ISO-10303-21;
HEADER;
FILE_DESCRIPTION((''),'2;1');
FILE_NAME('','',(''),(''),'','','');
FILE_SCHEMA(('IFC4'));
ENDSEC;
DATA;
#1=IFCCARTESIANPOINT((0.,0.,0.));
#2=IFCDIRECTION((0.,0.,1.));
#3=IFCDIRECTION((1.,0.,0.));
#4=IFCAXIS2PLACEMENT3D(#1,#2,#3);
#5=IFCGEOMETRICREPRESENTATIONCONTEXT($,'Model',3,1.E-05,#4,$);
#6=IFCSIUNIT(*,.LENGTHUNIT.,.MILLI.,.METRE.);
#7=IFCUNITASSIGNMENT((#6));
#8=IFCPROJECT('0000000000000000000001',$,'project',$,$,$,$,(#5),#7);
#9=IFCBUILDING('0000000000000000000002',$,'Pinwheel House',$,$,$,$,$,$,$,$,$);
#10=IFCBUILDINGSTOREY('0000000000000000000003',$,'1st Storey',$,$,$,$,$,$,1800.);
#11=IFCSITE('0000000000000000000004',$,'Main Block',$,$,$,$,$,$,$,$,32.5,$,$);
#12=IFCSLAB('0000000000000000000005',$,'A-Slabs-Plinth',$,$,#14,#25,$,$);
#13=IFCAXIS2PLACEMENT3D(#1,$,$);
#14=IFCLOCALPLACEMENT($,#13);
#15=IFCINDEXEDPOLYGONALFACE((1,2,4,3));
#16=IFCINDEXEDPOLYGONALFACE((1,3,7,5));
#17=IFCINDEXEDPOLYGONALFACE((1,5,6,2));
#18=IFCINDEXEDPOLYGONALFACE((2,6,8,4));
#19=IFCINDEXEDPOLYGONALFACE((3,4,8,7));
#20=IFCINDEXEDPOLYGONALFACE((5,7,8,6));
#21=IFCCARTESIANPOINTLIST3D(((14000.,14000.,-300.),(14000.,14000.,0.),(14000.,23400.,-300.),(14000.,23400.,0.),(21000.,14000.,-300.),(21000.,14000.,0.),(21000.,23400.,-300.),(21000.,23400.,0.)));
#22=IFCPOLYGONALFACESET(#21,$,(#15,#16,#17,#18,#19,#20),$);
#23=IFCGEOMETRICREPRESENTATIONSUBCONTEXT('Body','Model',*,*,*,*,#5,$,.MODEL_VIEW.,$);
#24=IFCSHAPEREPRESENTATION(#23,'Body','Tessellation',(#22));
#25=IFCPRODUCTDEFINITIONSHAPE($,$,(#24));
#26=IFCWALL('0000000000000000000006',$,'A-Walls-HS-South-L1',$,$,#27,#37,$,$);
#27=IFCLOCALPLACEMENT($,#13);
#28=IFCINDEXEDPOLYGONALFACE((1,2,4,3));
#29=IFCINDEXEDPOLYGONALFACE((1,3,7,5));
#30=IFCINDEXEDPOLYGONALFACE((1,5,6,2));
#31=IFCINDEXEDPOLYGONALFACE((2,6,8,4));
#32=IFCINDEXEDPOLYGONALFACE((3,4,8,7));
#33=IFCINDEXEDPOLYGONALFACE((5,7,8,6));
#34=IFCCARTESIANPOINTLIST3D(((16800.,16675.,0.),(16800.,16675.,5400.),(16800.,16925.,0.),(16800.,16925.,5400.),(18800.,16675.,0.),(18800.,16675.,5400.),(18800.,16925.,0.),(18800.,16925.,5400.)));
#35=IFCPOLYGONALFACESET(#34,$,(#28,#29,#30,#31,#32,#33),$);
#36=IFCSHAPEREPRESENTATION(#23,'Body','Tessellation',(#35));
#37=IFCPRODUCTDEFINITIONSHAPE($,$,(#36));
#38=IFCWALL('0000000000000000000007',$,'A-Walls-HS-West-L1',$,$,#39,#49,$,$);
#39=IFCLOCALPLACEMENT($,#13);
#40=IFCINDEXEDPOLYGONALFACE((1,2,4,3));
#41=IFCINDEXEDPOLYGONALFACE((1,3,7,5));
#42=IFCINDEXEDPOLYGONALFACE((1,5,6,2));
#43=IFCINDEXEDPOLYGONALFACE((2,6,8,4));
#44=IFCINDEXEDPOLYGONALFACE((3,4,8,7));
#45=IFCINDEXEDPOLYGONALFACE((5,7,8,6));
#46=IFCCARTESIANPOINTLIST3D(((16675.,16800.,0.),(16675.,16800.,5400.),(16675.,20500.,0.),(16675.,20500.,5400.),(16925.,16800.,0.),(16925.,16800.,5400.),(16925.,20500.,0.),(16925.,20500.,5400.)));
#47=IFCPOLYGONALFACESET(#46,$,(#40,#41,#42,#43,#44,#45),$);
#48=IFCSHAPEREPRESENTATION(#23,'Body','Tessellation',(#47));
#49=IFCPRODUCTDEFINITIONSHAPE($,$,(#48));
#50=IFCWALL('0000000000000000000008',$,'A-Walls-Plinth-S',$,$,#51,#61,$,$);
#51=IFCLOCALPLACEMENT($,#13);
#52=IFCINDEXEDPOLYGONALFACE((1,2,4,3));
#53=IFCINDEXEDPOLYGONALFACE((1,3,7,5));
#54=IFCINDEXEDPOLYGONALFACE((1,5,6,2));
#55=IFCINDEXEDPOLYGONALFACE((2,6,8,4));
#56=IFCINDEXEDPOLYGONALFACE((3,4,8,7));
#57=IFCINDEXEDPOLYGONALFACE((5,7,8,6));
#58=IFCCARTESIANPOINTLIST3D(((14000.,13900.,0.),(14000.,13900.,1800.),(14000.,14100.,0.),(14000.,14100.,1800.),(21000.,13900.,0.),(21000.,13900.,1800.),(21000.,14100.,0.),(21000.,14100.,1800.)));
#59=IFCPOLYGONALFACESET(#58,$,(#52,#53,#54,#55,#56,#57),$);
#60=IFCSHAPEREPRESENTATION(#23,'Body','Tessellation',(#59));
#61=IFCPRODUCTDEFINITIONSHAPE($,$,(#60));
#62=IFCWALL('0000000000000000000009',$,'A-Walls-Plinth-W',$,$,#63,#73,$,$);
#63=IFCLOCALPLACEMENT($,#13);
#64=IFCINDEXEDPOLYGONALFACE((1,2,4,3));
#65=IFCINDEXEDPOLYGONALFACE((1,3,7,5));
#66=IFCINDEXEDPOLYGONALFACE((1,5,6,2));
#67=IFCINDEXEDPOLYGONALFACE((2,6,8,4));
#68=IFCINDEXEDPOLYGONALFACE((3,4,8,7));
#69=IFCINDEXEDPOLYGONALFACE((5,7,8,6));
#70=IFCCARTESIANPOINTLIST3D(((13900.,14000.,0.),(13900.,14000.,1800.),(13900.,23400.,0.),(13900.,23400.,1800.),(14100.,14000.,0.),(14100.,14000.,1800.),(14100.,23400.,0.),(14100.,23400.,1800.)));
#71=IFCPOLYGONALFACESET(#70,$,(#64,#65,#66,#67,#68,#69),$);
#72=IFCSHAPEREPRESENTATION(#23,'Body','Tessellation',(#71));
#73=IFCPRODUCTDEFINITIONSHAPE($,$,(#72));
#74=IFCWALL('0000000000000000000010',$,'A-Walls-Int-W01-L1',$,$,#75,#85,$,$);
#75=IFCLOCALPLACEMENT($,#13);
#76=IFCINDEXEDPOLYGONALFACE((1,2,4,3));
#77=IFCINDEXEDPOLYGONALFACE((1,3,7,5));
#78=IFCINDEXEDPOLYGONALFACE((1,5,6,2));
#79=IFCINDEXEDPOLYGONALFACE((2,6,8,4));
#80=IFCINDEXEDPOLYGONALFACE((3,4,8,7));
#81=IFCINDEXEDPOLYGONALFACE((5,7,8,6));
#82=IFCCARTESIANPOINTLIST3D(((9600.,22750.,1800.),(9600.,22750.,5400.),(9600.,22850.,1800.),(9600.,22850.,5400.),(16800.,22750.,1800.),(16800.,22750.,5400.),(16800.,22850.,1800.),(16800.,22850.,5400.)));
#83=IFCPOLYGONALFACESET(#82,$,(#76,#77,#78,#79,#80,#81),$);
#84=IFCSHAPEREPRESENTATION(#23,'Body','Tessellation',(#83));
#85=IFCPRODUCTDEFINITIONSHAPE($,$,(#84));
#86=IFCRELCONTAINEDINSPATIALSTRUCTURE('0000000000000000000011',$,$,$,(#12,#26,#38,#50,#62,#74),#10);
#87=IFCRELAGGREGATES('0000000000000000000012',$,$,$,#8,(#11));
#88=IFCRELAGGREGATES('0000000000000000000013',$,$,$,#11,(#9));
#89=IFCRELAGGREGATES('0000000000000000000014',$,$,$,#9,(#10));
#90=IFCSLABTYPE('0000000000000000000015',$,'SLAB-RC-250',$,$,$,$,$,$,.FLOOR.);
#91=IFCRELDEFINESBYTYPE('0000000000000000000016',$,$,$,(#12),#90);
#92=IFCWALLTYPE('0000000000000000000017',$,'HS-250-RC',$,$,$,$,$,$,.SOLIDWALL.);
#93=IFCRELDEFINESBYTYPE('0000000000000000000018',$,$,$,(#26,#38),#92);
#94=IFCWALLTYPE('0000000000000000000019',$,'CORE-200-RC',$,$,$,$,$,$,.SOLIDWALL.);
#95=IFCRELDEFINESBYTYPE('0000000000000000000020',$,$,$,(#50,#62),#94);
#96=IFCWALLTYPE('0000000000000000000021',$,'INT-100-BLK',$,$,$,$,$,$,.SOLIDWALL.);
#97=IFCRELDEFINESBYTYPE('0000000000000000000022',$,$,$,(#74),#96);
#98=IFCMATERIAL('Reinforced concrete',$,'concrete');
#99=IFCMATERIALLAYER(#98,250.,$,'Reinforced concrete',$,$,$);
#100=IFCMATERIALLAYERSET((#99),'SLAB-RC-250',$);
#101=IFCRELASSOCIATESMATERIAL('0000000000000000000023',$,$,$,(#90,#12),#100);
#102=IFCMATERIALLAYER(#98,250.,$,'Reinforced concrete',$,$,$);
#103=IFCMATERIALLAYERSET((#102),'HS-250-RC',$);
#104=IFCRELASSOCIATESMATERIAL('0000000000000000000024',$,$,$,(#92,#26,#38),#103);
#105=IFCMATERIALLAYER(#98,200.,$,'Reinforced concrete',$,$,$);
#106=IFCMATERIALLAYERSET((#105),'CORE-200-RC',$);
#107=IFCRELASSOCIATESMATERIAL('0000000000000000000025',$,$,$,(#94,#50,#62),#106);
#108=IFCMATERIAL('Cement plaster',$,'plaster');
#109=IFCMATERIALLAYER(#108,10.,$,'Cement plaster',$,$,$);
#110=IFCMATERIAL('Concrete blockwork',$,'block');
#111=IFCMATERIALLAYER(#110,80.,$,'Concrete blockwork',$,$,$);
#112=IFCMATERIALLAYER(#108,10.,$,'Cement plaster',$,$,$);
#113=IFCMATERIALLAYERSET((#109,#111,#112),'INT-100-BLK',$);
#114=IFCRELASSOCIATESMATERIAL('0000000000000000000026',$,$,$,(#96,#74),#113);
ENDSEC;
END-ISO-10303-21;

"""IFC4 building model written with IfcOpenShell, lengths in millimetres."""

from ifc_helpers import new_model, si_unit, frame, origin_with_axes, place, context, subcontext, project, spatial, indexed_curve, outline, extrude, material, layer, layer_set, layer_usage, type_object, element, save


model = new_model("IFC4")

# Units and contexts
model_context = context("Model", 3, precision=1e-05, world=origin_with_axes())
body_context = subcontext(model_context, "Body", "Model", "MODEL_VIEW")
ifc_project = project(units=[si_unit("LENGTHUNIT", "METRE", prefix="MILLI")], contexts=[model_context])

# Site, building, storey
site = spatial("IfcSite", under=ifc_project, Name="Main Block", RefElevation=32.5)
building = spatial("IfcBuilding", under=site, Name="Pinwheel House")
storey = spatial("IfcBuildingStorey", under=building, Name="1st Storey", Elevation=1800.0)

# Slab
ifc_material_1 = material(Name="Reinforced concrete", Category="concrete")
ifc_layer_1 = layer(ifc_material_1, 250.0, Name="Reinforced concrete")
ifc_layer_set_1 = layer_set([ifc_layer_1], Name="SLAB-RC-250")
slab_type = type_object("IfcSlabType", Name="SLAB-RC-250", PredefinedType="FLOOR", material=ifc_layer_set_1)
ifc_layer_usage_1 = layer_usage(ifc_layer_set_1, "AXIS3", "POSITIVE", 0.0)
slab_1_placement = place(None, frame((0.0, 0.0, -300.0), z_axis=(0.0, 0.0, 1.0), x_axis=(1.0, 0.0, 0.0)))
element("IfcSlab", 1, at=slab_1_placement, inside=storey, type_object=slab_type, material=ifc_layer_usage_1, Name="A-Slabs-Plinth", context=body_context, shape_type="SweptSolid", body=[
    extrude(outline(indexed_curve([(14000.0, 14000.0), (21000.0, 14000.0), (21000.0, 23400.0), (14000.0, 23400.0)])), None, (0.0, 0.0, 1.0), 300.0),
])

# Walls
ifc_layer_2 = layer(ifc_material_1, 250.0, Name="Reinforced concrete")
ifc_layer_set_2 = layer_set([ifc_layer_2], Name="HS-250-RC")
ifc_layer_usage_2 = layer_usage(ifc_layer_set_2, "AXIS2", "POSITIVE", 0.0)
wall_type_1 = type_object("IfcWallType", Name="HS-250-RC", PredefinedType="SOLIDWALL", material=ifc_layer_set_2)
wall_1_placement = place(None, frame((16800.0, 16675.0, 0.0), z_axis=(0.0, 0.0, 1.0), x_axis=(1.0, 0.0, 0.0)))
element("IfcWall", 2, at=wall_1_placement, inside=storey, type_object=wall_type_1, material=ifc_layer_usage_2, Name="A-Walls-HS-South-L1", context=body_context, shape_type="SweptSolid", body=[
    extrude(outline(indexed_curve([(0.0, 0.0), (0.0, 250.0), (2000.0, 250.0), (2000.0, 0.0), (0.0, 0.0)], self_intersect=False)), origin_with_axes(), (0.0, 0.0, 1.0), 5400.0),
])
ifc_layer_usage_3 = layer_usage(ifc_layer_set_2, "AXIS2", "POSITIVE", 0.0)
wall_2_placement = place(None, frame((16675.0, 20500.0, 0.0), z_axis=(0.0, 0.0, 1.0), x_axis=(0.0, -1.0, 0.0)))
element("IfcWall", 3, at=wall_2_placement, inside=storey, type_object=wall_type_1, material=ifc_layer_usage_3, Name="A-Walls-HS-West-L1", context=body_context, shape_type="SweptSolid", body=[
    extrude(outline(indexed_curve([(0.0, 0.0), (0.0, 250.0), (3700.0, 250.0), (3700.0, 0.0), (0.0, 0.0)], self_intersect=False)), origin_with_axes(), (0.0, 0.0, 1.0), 5400.0),
])
ifc_layer_3 = layer(ifc_material_1, 200.0, Name="Reinforced concrete")
ifc_layer_set_3 = layer_set([ifc_layer_3], Name="CORE-200-RC")
ifc_layer_usage_4 = layer_usage(ifc_layer_set_3, "AXIS2", "POSITIVE", 0.0)
wall_type_2 = type_object("IfcWallType", Name="CORE-200-RC", PredefinedType="SOLIDWALL", material=ifc_layer_set_3)
wall_3_placement = place(None, frame((14000.0, 13900.0, 0.0), z_axis=(0.0, 0.0, 1.0), x_axis=(1.0, 0.0, 0.0)))
element("IfcWall", 4, at=wall_3_placement, inside=storey, type_object=wall_type_2, material=ifc_layer_usage_4, Name="A-Walls-Plinth-S", context=body_context, shape_type="SweptSolid", body=[
    extrude(outline(indexed_curve([(0.0, 0.0), (0.0, 200.0), (7000.0, 200.0), (7000.0, 0.0), (0.0, 0.0)], self_intersect=False)), origin_with_axes(), (0.0, 0.0, 1.0), 1800.0),
])
ifc_layer_usage_5 = layer_usage(ifc_layer_set_3, "AXIS2", "POSITIVE", 0.0)
wall_4_placement = place(None, frame((13900.0, 23400.0, 0.0), z_axis=(0.0, 0.0, 1.0), x_axis=(0.0, -1.0, 0.0)))
element("IfcWall", 5, at=wall_4_placement, inside=storey, type_object=wall_type_2, material=ifc_layer_usage_5, Name="A-Walls-Plinth-W", context=body_context, shape_type="SweptSolid", body=[
    extrude(outline(indexed_curve([(0.0, 0.0), (0.0, 200.0), (9400.0, 200.0), (9400.0, 0.0), (0.0, 0.0)], self_intersect=False)), origin_with_axes(), (0.0, 0.0, 1.0), 1800.0),
])
ifc_material_2 = material(Name="Cement plaster", Category="plaster")
ifc_layer_4 = layer(ifc_material_2, 10.0, Name="Cement plaster")
ifc_material_3 = material(Name="Concrete blockwork", Category="block")
ifc_layer_5 = layer(ifc_material_3, 80.0, Name="Concrete blockwork")
ifc_layer_6 = layer(ifc_material_2, 10.0, Name="Cement plaster")
ifc_layer_set_4 = layer_set([ifc_layer_4, ifc_layer_5, ifc_layer_6], Name="INT-100-BLK")
ifc_layer_usage_6 = layer_usage(ifc_layer_set_4, "AXIS2", "POSITIVE", 0.0)
wall_type_3 = type_object("IfcWallType", Name="INT-100-BLK", PredefinedType="SOLIDWALL", material=ifc_layer_set_4)
wall_5_placement = place(None, frame((9600.0, 22750.0, 1800.0), z_axis=(0.0, 0.0, 1.0), x_axis=(1.0, 0.0, 0.0)))
element("IfcWall", 6, at=wall_5_placement, inside=storey, type_object=wall_type_3, material=ifc_layer_usage_6, Name="A-Walls-Int-W01-L1", context=body_context, shape_type="SweptSolid", body=[
    extrude(outline(indexed_curve([(0.0, 0.0), (0.0, 100.0), (7200.0, 100.0), (7200.0, 0.0), (0.0, 0.0)], self_intersect=False)), origin_with_axes(), (0.0, 0.0, 1.0), 3600.0),
])

save(model, "model.ifc")
